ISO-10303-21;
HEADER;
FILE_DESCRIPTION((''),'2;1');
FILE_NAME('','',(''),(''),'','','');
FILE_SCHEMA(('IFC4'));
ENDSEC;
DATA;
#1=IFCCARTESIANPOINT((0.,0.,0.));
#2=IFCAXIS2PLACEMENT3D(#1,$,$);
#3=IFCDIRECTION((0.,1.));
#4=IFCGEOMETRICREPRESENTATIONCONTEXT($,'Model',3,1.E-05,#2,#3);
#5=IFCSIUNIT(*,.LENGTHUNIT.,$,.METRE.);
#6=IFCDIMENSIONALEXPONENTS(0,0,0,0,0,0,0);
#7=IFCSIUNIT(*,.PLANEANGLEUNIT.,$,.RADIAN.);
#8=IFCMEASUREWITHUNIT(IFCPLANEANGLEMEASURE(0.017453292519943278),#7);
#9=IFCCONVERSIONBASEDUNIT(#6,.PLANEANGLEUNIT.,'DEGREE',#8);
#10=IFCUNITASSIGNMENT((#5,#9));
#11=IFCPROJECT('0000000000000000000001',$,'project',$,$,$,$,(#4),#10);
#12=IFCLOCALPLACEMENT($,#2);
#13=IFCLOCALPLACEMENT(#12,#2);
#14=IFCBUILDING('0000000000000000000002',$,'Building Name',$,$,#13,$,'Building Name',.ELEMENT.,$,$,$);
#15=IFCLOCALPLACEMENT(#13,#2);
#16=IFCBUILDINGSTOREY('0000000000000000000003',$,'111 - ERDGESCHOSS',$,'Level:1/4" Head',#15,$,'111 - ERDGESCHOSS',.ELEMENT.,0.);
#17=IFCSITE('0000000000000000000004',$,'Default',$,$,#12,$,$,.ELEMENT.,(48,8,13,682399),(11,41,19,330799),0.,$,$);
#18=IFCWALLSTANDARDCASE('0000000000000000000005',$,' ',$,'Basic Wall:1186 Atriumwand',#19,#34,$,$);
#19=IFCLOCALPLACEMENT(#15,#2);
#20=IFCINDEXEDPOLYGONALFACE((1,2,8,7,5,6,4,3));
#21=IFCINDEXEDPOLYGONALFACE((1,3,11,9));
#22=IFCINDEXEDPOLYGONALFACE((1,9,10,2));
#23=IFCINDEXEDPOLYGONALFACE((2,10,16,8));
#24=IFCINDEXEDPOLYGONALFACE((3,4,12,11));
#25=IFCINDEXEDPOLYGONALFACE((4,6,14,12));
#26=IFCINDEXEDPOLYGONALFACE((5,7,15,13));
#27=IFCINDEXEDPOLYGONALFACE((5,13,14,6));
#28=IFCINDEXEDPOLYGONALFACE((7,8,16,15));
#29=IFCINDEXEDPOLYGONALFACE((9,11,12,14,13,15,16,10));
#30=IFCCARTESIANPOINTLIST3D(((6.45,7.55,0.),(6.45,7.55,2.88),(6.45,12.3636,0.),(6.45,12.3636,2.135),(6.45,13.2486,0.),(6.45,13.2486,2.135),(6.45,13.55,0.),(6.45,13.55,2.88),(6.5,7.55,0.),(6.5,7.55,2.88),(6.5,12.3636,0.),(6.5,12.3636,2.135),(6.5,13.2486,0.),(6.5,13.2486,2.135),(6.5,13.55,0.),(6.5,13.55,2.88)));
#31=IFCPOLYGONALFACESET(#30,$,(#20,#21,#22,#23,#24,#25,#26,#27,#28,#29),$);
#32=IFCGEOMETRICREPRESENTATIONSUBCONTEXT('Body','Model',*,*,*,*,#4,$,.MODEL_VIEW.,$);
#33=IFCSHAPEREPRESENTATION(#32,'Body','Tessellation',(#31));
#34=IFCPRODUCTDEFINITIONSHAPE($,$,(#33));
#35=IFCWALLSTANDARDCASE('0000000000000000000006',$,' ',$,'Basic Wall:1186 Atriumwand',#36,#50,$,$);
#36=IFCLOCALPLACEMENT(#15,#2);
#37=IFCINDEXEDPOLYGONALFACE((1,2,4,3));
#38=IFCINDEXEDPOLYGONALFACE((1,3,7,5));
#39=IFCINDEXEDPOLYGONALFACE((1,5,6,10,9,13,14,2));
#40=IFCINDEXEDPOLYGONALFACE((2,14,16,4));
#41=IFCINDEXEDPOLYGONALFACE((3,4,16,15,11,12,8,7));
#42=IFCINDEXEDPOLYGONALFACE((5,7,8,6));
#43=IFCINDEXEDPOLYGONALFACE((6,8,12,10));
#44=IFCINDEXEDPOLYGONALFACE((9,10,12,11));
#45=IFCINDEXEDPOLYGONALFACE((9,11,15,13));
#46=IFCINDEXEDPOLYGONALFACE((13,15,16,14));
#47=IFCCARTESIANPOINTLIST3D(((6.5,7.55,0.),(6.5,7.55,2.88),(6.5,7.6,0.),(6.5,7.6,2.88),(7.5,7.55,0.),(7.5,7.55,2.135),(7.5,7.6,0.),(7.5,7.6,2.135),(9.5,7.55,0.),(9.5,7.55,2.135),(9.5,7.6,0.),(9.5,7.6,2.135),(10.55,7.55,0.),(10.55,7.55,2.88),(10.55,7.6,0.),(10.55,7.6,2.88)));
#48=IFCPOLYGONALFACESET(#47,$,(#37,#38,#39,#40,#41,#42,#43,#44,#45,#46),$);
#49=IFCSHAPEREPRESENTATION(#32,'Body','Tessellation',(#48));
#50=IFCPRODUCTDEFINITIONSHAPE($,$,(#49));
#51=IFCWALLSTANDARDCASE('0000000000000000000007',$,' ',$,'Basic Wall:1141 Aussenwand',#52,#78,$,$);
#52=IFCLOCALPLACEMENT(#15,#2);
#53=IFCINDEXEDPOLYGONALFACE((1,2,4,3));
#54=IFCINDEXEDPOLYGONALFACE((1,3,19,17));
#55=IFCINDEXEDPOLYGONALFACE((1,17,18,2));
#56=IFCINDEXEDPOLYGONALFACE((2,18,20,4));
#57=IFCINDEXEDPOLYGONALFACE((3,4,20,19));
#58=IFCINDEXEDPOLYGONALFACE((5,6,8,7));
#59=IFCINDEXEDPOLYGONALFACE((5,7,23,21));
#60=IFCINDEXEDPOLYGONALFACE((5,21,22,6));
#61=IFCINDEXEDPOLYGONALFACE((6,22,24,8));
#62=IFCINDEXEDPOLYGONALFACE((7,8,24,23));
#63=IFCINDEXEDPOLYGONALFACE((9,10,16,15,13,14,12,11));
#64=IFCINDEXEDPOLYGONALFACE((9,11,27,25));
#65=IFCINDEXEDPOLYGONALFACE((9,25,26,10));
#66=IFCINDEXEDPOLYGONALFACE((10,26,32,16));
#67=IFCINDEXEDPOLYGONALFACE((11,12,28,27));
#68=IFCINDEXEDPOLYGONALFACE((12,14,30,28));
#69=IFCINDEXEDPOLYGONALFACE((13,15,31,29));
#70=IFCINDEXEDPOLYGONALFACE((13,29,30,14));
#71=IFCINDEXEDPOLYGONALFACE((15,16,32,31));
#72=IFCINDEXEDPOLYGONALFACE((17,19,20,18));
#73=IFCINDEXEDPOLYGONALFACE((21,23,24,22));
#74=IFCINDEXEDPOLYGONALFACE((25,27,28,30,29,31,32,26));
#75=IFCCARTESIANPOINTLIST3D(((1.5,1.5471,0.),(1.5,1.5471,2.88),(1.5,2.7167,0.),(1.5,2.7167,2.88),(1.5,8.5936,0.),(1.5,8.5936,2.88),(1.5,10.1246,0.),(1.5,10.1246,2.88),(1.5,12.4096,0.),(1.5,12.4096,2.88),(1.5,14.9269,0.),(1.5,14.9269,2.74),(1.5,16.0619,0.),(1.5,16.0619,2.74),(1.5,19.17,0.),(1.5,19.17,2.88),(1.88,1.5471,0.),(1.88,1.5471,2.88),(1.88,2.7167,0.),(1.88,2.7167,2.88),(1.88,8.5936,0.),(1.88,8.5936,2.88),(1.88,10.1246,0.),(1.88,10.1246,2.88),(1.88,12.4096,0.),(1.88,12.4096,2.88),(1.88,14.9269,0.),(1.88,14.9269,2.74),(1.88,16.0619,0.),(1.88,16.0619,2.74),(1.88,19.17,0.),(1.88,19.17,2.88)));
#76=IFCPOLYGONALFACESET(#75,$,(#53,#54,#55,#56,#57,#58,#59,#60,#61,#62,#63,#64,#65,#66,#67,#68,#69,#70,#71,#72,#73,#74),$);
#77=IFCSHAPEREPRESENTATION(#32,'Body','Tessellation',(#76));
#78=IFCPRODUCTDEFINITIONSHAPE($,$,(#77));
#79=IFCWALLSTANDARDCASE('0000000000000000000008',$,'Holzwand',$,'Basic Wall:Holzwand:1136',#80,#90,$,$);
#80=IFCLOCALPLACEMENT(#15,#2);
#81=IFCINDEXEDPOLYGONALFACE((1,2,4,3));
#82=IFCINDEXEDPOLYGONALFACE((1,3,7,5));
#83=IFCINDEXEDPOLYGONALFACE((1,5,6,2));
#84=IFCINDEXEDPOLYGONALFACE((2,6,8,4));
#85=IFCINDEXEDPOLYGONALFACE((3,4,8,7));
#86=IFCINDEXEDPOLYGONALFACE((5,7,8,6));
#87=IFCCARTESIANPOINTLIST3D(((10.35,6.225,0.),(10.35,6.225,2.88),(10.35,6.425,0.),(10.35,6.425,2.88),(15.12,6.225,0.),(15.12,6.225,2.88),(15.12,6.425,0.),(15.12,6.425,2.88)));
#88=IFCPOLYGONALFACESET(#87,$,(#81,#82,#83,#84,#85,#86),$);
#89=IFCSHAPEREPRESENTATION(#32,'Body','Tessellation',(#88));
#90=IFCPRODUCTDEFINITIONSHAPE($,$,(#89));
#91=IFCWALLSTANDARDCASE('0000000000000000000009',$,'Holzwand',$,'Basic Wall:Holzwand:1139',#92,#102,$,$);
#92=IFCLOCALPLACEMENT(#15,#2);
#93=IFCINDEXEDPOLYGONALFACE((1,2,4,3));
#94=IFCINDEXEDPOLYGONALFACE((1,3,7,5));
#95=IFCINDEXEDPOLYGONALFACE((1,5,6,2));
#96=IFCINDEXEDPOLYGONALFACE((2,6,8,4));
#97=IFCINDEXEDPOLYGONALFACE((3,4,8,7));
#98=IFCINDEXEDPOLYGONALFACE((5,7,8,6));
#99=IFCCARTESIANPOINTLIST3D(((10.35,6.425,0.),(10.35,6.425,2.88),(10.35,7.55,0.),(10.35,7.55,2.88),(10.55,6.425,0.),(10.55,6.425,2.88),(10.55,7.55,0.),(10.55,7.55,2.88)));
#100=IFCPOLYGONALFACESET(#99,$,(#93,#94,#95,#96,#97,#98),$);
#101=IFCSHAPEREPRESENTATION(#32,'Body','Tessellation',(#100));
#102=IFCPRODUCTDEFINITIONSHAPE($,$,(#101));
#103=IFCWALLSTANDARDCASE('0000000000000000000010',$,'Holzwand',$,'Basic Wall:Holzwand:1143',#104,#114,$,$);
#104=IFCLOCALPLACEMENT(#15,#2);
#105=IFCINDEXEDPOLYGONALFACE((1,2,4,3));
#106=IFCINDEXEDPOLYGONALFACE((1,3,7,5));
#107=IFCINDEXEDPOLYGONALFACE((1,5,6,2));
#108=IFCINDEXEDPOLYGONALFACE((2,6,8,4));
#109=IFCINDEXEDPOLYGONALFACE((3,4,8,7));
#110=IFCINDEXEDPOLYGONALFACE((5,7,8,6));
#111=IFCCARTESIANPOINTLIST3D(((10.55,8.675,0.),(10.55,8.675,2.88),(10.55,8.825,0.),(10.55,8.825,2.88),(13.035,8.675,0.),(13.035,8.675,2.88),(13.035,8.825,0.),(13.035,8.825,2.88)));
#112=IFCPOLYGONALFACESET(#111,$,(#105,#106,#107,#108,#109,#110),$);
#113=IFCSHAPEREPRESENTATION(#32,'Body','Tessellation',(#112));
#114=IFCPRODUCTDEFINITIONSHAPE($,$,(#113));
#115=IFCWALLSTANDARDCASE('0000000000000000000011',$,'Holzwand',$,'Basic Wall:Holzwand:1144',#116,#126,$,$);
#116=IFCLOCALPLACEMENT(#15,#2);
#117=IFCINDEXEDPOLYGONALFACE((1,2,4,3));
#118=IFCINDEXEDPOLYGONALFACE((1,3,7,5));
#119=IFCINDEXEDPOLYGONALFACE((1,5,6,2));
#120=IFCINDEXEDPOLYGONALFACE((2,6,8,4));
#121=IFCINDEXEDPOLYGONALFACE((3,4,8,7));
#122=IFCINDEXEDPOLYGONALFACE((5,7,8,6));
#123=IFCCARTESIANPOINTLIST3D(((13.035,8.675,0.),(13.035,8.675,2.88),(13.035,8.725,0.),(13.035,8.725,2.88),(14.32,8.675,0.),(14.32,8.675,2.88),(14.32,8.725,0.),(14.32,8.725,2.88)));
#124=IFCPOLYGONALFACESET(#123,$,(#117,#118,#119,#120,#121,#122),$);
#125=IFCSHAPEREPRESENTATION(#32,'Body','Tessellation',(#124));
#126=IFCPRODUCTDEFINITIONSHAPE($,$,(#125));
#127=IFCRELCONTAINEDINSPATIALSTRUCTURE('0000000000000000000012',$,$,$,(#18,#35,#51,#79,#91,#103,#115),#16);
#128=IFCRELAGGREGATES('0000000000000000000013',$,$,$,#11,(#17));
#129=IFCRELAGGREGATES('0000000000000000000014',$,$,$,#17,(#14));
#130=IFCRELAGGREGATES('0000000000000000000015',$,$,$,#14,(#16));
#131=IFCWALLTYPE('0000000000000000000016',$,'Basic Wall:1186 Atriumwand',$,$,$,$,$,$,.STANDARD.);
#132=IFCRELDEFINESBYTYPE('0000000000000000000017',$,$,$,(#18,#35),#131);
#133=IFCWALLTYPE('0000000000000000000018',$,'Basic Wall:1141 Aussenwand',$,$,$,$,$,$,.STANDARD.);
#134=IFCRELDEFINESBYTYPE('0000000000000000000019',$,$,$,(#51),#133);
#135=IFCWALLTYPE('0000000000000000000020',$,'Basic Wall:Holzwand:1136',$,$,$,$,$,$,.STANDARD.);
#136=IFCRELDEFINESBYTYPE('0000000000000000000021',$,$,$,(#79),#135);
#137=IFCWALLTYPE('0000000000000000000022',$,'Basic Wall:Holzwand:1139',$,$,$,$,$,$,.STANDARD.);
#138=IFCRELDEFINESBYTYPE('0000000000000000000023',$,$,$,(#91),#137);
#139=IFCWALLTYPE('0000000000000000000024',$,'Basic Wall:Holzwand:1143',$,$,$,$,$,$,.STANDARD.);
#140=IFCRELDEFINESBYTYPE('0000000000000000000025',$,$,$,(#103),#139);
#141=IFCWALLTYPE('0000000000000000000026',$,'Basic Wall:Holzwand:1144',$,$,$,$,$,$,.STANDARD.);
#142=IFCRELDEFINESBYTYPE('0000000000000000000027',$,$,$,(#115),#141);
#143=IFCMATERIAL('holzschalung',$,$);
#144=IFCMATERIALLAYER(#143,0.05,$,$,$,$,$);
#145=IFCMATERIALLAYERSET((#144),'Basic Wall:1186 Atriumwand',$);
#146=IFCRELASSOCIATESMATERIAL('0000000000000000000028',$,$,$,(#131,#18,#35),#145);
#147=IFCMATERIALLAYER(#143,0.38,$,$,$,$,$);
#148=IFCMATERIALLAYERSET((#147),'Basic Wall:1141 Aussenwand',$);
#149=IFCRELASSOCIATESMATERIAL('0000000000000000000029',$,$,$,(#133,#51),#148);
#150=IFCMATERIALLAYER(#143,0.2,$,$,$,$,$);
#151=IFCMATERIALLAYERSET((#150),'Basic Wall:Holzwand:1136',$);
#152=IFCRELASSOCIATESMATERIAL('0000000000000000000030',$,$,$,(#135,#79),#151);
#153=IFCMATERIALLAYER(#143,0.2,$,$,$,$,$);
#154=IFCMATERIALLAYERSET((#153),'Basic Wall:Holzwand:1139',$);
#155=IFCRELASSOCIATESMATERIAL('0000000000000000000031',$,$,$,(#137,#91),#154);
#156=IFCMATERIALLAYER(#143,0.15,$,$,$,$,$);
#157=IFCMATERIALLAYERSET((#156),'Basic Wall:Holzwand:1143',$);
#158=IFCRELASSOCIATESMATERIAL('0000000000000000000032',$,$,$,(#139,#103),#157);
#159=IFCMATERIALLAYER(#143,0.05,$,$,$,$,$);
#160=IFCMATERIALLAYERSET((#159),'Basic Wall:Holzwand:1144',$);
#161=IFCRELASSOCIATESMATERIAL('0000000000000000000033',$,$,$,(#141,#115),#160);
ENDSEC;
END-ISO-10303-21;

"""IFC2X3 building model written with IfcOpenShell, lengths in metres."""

from ifc_helpers import new_model, entity, si_unit, converted_unit, direction, frame, frame_2d, origin, place, context, subcontext, project, spatial, rectangle, extrude, material, layer, layer_set, layer_usage, type_object, element, save


model = new_model("IFC2X3")

# Units and contexts
model_context = context("Model", 3, precision=1e-05, world=origin(), true_north=direction((0.0, 1.0)))
body_context = subcontext(model_context, "Body", "Model", "MODEL_VIEW")
ifc_project = project(units=[si_unit("LENGTHUNIT", "METRE"), converted_unit("PLANEANGLEUNIT", "DEGREE", entity("IfcPlaneAngleMeasure", 0.017453292519943278), si_unit("PLANEANGLEUNIT", "RADIAN"), dimensions=[0, 0, 0, 0, 0, 0, 0])], contexts=[model_context])

# Site, building, storey
site_placement = place(None, origin())
site = spatial("IfcSite", under=ifc_project, at=site_placement, Name="Default", CompositionType="ELEMENT", RefLatitude=(48, 8, 13, 682399), RefLongitude=(11, 41, 19, 330799), RefElevation=0.0)
building_placement = place(site_placement, origin())
building = spatial("IfcBuilding", under=site, at=building_placement, Name="Building Name", LongName="Building Name", CompositionType="ELEMENT")
storey_placement = place(building_placement, origin())
storey = spatial("IfcBuildingStorey", under=building, at=storey_placement, Name="111 - ERDGESCHOSS", ObjectType="Level:1/4\" Head", LongName="111 - ERDGESCHOSS", CompositionType="ELEMENT", Elevation=0.0)

# Walls, openings
ifc_material_1 = material(Name="holzschalung")
ifc_layer_1 = layer(ifc_material_1, 0.05)
ifc_layer_set_1 = layer_set([ifc_layer_1], Name="Basic Wall:1186 Atriumwand")
ifc_layer_usage_1 = layer_usage(ifc_layer_set_1, "AXIS2", "NEGATIVE", 0.025)
wall_type_1 = type_object("IfcWallType", Name="Basic Wall:1186 Atriumwand", PredefinedType="STANDARD", material=ifc_layer_set_1)
wall_1_placement = place(storey_placement, frame((6.475, 7.55, 0.0), z_axis=(0.0, 0.0, 1.0), x_axis=(0.0, 1.0, 0.0)))
wall_1 = element("IfcWallStandardCase", 1, at=wall_1_placement, inside=storey, type_object=wall_type_1, material=ifc_layer_usage_1, Name=" ", ObjectType="Basic Wall:1186 Atriumwand", context=body_context, shape_type="SweptSolid", body=[
    extrude(rectangle(XDim=6.0, YDim=0.05, at=frame_2d((3.0, 0.0), x_axis=(1.0, 0.0))), origin(), (0.0, 0.0, 1.0), 2.88),
])
opening_1_placement = place(wall_1_placement, frame((-7.55, 6.475, 0.0), z_axis=(0.0, 0.0, 1.0), x_axis=(0.0, -1.0, 0.0)))
element("IfcOpeningElement", 2, at=opening_1_placement, cuts=wall_1, ObjectType="Opening", context=body_context, shape_type="SweptSolid", body=[
    extrude(rectangle(XDim=2.135, YDim=0.885, at=frame_2d((0.0, 0.0), x_axis=(0.0, 1.0))), frame((6.5005, 12.8061, 1.0675), z_axis=(-1.0, 0.0, 0.0), x_axis=(0.0, -1.0, 0.0)), (0.0, 0.0, 1.0), 0.051),
])
ifc_layer_usage_2 = layer_usage(ifc_layer_set_1, "AXIS2", "NEGATIVE", 0.025)
wall_2_placement = place(storey_placement, frame((10.55, 7.575, 0.0), z_axis=(0.0, 0.0, 1.0), x_axis=(-1.0, 0.0, 0.0)))
wall_2 = element("IfcWallStandardCase", 3, at=wall_2_placement, inside=storey, type_object=wall_type_1, material=ifc_layer_usage_2, Name=" ", ObjectType="Basic Wall:1186 Atriumwand", context=body_context, shape_type="SweptSolid", body=[
    extrude(rectangle(XDim=4.05, YDim=0.05, at=frame_2d((2.025, 0.0), x_axis=(1.0, 0.0))), origin(), (0.0, 0.0, 1.0), 2.88),
])
opening_2_placement = place(wall_2_placement, frame((10.55, 7.575, 0.0), z_axis=(0.0, 0.0, 1.0), x_axis=(-1.0, 0.0, 0.0)))
element("IfcOpeningElement", 4, at=opening_2_placement, cuts=wall_2, ObjectType="Opening", context=body_context, shape_type="SweptSolid", body=[
    extrude(rectangle(XDim=2.135, YDim=2.0, at=frame_2d((0.0, 0.0), x_axis=(0.0, 1.0))), frame((8.5, 7.6005, 1.0675), z_axis=(0.0, -1.0, 0.0), x_axis=(1.0, 0.0, 0.0)), (0.0, 0.0, 1.0), 0.051),
])

# Wall, openings
ifc_layer_2 = layer(ifc_material_1, 0.38)
ifc_layer_set_2 = layer_set([ifc_layer_2], Name="Basic Wall:1141 Aussenwand")
ifc_layer_usage_3 = layer_usage(ifc_layer_set_2, "AXIS2", "NEGATIVE", 0.19)
wall_type_2 = type_object("IfcWallType", Name="Basic Wall:1141 Aussenwand", PredefinedType="STANDARD", material=ifc_layer_set_2)
wall_3_placement = place(storey_placement, frame((1.69, 1.5471, 0.0), z_axis=(0.0, 0.0, 1.0), x_axis=(0.0, 1.0, 0.0)))
wall_3 = element("IfcWallStandardCase", 5, at=wall_3_placement, inside=storey, type_object=wall_type_2, material=ifc_layer_usage_3, Name=" ", ObjectType="Basic Wall:1141 Aussenwand", context=body_context, shape_type="SweptSolid", body=[
    extrude(rectangle(XDim=17.6229, YDim=0.38, at=frame_2d((8.8114, 0.0), x_axis=(-1.0, 0.0))), origin(), (0.0, 0.0, 1.0), 2.88),
])
opening_3_placement = place(wall_3_placement, origin())
element("IfcOpeningElement", 6, at=opening_3_placement, cuts=wall_3, ObjectType="Opening", context=body_context, shape_type="SweptSolid", body=[
    extrude(rectangle(XDim=2.88, YDim=1.135, at=frame_2d((0.0, 0.0), x_axis=(0.0, 1.0))), frame((9.145, -0.19, 1.44), z_axis=(0.0, 1.0, 0.0), x_axis=(-1.0, 0.0, 0.0)), (0.0, 0.0, 1.0), 0.38),
])
opening_4_placement = place(wall_3_placement, origin())
element("IfcOpeningElement", 7, at=opening_4_placement, cuts=wall_3, ObjectType="Opening", context=body_context, shape_type="SweptSolid", body=[
    extrude(rectangle(XDim=2.88, YDim=1.135, at=frame_2d((0.0, 0.0), x_axis=(0.0, 1.0))), frame((6.4789, -0.19, 1.44), z_axis=(0.0, 1.0, 0.0), x_axis=(-1.0, 0.0, 0.0)), (0.0, 0.0, 1.0), 0.38),
])
opening_5_placement = place(wall_3_placement, origin())
element("IfcOpeningElement", 8, at=opening_5_placement, cuts=wall_3, ObjectType="Opening", context=body_context, shape_type="SweptSolid", body=[
    extrude(rectangle(XDim=2.88, YDim=1.135, at=frame_2d((0.0, 0.0), x_axis=(0.0, 1.0))), frame((1.7371, -0.19, 1.44), z_axis=(0.0, 1.0, 0.0), x_axis=(-1.0, 0.0, 0.0)), (0.0, 0.0, 1.0), 0.38),
])
opening_6_placement = place(wall_3_placement, origin())
element("IfcOpeningElement", 9, at=opening_6_placement, cuts=wall_3, ObjectType="Opening", context=body_context, shape_type="SweptSolid", body=[
    extrude(rectangle(XDim=2.88, YDim=1.15, at=frame_2d((0.0, 0.0), x_axis=(0.0, 1.0))), frame((10.2875, -0.19, 1.44), z_axis=(0.0, 1.0, 0.0), x_axis=(-1.0, 0.0, 0.0)), (0.0, 0.0, 1.0), 0.38),
])
opening_7_placement = place(wall_3_placement, origin())
element("IfcOpeningElement", 10, at=opening_7_placement, cuts=wall_3, ObjectType="Opening", context=body_context, shape_type="SweptSolid", body=[
    extrude(rectangle(XDim=2.74, YDim=1.135, at=frame_2d((0.0, 0.0), x_axis=(0.0, 1.0))), frame((13.9473, -0.19, 1.37), z_axis=(0.0, 1.0, 0.0), x_axis=(-1.0, 0.0, 0.0)), (0.0, 0.0, 1.0), 0.38),
])
opening_8_placement = place(wall_3_placement, origin())
element("IfcOpeningElement", 11, at=opening_8_placement, cuts=wall_3, ObjectType="Opening", context=body_context, shape_type="SweptSolid", body=[
    extrude(rectangle(XDim=2.88, YDim=3.608, at=frame_2d((0.0, 0.0), x_axis=(0.0, 1.0))), frame((4.1074, -0.19, 1.44), z_axis=(0.0, 1.0, 0.0), x_axis=(-1.0, 0.0, 0.0)), (0.0, 0.0, 1.0), 0.38),
])

# Walls
ifc_layer_3 = layer(ifc_material_1, 0.2)
ifc_layer_set_3 = layer_set([ifc_layer_3], Name="Basic Wall:Holzwand:1136")
ifc_layer_usage_4 = layer_usage(ifc_layer_set_3, "AXIS2", "NEGATIVE", 0.1)
wall_type_3 = type_object("IfcWallType", Name="Basic Wall:Holzwand:1136", PredefinedType="STANDARD", material=ifc_layer_set_3)
wall_4_placement = place(storey_placement, frame((15.12, 6.325, 0.0), z_axis=(0.0, 0.0, 1.0), x_axis=(-1.0, 0.0, 0.0)))
element("IfcWallStandardCase", 12, at=wall_4_placement, inside=storey, type_object=wall_type_3, material=ifc_layer_usage_4, Name="Holzwand", ObjectType="Basic Wall:Holzwand:1136", context=body_context, shape_type="SweptSolid", body=[
    extrude(rectangle(XDim=4.77, YDim=0.2, at=frame_2d((2.385, 0.0), x_axis=(-1.0, 0.0))), origin(), (0.0, 0.0, 1.0), 2.88),
])
ifc_layer_4 = layer(ifc_material_1, 0.2)
ifc_layer_set_4 = layer_set([ifc_layer_4], Name="Basic Wall:Holzwand:1139")
ifc_layer_usage_5 = layer_usage(ifc_layer_set_4, "AXIS2", "NEGATIVE", 0.1)
wall_type_4 = type_object("IfcWallType", Name="Basic Wall:Holzwand:1139", PredefinedType="STANDARD", material=ifc_layer_set_4)
wall_5_placement = place(storey_placement, frame((10.45, 7.55, 0.0), z_axis=(0.0, 0.0, 1.0), x_axis=(0.0, -1.0, 0.0)))
element("IfcWallStandardCase", 13, at=wall_5_placement, inside=storey, type_object=wall_type_4, material=ifc_layer_usage_5, Name="Holzwand", ObjectType="Basic Wall:Holzwand:1139", context=body_context, shape_type="SweptSolid", body=[
    extrude(rectangle(XDim=1.125, YDim=0.2, at=frame_2d((0.5625, 0.0), x_axis=(-1.0, 0.0))), origin(), (0.0, 0.0, 1.0), 2.88),
])
ifc_layer_5 = layer(ifc_material_1, 0.15)
ifc_layer_set_5 = layer_set([ifc_layer_5], Name="Basic Wall:Holzwand:1143")
ifc_layer_usage_6 = layer_usage(ifc_layer_set_5, "AXIS2", "NEGATIVE", 0.075)
wall_type_5 = type_object("IfcWallType", Name="Basic Wall:Holzwand:1143", PredefinedType="STANDARD", material=ifc_layer_set_5)
wall_6_placement = place(storey_placement, frame((13.035, 8.75, 0.0), z_axis=(0.0, 0.0, 1.0), x_axis=(-1.0, 0.0, 0.0)))
element("IfcWallStandardCase", 14, at=wall_6_placement, inside=storey, type_object=wall_type_5, material=ifc_layer_usage_6, Name="Holzwand", ObjectType="Basic Wall:Holzwand:1143", context=body_context, shape_type="SweptSolid", body=[
    extrude(rectangle(XDim=2.485, YDim=0.15, at=frame_2d((1.2425, 0.0), x_axis=(-1.0, 0.0))), origin(), (0.0, 0.0, 1.0), 2.88),
])
ifc_layer_6 = layer(ifc_material_1, 0.05)
ifc_layer_set_6 = layer_set([ifc_layer_6], Name="Basic Wall:Holzwand:1144")
ifc_layer_usage_7 = layer_usage(ifc_layer_set_6, "AXIS2", "NEGATIVE", 0.025)
wall_type_6 = type_object("IfcWallType", Name="Basic Wall:Holzwand:1144", PredefinedType="STANDARD", material=ifc_layer_set_6)
wall_7_placement = place(storey_placement, frame((13.035, 8.7, 0.0)))
element("IfcWallStandardCase", 15, at=wall_7_placement, inside=storey, type_object=wall_type_6, material=ifc_layer_usage_7, Name="Holzwand", ObjectType="Basic Wall:Holzwand:1144", context=body_context, shape_type="SweptSolid", body=[
    extrude(rectangle(XDim=1.285, YDim=0.05, at=frame_2d((0.6425, 0.0), x_axis=(-1.0, 0.0))), origin(), (0.0, 0.0, 1.0), 2.88),
])

save(model, "model.ifc")
